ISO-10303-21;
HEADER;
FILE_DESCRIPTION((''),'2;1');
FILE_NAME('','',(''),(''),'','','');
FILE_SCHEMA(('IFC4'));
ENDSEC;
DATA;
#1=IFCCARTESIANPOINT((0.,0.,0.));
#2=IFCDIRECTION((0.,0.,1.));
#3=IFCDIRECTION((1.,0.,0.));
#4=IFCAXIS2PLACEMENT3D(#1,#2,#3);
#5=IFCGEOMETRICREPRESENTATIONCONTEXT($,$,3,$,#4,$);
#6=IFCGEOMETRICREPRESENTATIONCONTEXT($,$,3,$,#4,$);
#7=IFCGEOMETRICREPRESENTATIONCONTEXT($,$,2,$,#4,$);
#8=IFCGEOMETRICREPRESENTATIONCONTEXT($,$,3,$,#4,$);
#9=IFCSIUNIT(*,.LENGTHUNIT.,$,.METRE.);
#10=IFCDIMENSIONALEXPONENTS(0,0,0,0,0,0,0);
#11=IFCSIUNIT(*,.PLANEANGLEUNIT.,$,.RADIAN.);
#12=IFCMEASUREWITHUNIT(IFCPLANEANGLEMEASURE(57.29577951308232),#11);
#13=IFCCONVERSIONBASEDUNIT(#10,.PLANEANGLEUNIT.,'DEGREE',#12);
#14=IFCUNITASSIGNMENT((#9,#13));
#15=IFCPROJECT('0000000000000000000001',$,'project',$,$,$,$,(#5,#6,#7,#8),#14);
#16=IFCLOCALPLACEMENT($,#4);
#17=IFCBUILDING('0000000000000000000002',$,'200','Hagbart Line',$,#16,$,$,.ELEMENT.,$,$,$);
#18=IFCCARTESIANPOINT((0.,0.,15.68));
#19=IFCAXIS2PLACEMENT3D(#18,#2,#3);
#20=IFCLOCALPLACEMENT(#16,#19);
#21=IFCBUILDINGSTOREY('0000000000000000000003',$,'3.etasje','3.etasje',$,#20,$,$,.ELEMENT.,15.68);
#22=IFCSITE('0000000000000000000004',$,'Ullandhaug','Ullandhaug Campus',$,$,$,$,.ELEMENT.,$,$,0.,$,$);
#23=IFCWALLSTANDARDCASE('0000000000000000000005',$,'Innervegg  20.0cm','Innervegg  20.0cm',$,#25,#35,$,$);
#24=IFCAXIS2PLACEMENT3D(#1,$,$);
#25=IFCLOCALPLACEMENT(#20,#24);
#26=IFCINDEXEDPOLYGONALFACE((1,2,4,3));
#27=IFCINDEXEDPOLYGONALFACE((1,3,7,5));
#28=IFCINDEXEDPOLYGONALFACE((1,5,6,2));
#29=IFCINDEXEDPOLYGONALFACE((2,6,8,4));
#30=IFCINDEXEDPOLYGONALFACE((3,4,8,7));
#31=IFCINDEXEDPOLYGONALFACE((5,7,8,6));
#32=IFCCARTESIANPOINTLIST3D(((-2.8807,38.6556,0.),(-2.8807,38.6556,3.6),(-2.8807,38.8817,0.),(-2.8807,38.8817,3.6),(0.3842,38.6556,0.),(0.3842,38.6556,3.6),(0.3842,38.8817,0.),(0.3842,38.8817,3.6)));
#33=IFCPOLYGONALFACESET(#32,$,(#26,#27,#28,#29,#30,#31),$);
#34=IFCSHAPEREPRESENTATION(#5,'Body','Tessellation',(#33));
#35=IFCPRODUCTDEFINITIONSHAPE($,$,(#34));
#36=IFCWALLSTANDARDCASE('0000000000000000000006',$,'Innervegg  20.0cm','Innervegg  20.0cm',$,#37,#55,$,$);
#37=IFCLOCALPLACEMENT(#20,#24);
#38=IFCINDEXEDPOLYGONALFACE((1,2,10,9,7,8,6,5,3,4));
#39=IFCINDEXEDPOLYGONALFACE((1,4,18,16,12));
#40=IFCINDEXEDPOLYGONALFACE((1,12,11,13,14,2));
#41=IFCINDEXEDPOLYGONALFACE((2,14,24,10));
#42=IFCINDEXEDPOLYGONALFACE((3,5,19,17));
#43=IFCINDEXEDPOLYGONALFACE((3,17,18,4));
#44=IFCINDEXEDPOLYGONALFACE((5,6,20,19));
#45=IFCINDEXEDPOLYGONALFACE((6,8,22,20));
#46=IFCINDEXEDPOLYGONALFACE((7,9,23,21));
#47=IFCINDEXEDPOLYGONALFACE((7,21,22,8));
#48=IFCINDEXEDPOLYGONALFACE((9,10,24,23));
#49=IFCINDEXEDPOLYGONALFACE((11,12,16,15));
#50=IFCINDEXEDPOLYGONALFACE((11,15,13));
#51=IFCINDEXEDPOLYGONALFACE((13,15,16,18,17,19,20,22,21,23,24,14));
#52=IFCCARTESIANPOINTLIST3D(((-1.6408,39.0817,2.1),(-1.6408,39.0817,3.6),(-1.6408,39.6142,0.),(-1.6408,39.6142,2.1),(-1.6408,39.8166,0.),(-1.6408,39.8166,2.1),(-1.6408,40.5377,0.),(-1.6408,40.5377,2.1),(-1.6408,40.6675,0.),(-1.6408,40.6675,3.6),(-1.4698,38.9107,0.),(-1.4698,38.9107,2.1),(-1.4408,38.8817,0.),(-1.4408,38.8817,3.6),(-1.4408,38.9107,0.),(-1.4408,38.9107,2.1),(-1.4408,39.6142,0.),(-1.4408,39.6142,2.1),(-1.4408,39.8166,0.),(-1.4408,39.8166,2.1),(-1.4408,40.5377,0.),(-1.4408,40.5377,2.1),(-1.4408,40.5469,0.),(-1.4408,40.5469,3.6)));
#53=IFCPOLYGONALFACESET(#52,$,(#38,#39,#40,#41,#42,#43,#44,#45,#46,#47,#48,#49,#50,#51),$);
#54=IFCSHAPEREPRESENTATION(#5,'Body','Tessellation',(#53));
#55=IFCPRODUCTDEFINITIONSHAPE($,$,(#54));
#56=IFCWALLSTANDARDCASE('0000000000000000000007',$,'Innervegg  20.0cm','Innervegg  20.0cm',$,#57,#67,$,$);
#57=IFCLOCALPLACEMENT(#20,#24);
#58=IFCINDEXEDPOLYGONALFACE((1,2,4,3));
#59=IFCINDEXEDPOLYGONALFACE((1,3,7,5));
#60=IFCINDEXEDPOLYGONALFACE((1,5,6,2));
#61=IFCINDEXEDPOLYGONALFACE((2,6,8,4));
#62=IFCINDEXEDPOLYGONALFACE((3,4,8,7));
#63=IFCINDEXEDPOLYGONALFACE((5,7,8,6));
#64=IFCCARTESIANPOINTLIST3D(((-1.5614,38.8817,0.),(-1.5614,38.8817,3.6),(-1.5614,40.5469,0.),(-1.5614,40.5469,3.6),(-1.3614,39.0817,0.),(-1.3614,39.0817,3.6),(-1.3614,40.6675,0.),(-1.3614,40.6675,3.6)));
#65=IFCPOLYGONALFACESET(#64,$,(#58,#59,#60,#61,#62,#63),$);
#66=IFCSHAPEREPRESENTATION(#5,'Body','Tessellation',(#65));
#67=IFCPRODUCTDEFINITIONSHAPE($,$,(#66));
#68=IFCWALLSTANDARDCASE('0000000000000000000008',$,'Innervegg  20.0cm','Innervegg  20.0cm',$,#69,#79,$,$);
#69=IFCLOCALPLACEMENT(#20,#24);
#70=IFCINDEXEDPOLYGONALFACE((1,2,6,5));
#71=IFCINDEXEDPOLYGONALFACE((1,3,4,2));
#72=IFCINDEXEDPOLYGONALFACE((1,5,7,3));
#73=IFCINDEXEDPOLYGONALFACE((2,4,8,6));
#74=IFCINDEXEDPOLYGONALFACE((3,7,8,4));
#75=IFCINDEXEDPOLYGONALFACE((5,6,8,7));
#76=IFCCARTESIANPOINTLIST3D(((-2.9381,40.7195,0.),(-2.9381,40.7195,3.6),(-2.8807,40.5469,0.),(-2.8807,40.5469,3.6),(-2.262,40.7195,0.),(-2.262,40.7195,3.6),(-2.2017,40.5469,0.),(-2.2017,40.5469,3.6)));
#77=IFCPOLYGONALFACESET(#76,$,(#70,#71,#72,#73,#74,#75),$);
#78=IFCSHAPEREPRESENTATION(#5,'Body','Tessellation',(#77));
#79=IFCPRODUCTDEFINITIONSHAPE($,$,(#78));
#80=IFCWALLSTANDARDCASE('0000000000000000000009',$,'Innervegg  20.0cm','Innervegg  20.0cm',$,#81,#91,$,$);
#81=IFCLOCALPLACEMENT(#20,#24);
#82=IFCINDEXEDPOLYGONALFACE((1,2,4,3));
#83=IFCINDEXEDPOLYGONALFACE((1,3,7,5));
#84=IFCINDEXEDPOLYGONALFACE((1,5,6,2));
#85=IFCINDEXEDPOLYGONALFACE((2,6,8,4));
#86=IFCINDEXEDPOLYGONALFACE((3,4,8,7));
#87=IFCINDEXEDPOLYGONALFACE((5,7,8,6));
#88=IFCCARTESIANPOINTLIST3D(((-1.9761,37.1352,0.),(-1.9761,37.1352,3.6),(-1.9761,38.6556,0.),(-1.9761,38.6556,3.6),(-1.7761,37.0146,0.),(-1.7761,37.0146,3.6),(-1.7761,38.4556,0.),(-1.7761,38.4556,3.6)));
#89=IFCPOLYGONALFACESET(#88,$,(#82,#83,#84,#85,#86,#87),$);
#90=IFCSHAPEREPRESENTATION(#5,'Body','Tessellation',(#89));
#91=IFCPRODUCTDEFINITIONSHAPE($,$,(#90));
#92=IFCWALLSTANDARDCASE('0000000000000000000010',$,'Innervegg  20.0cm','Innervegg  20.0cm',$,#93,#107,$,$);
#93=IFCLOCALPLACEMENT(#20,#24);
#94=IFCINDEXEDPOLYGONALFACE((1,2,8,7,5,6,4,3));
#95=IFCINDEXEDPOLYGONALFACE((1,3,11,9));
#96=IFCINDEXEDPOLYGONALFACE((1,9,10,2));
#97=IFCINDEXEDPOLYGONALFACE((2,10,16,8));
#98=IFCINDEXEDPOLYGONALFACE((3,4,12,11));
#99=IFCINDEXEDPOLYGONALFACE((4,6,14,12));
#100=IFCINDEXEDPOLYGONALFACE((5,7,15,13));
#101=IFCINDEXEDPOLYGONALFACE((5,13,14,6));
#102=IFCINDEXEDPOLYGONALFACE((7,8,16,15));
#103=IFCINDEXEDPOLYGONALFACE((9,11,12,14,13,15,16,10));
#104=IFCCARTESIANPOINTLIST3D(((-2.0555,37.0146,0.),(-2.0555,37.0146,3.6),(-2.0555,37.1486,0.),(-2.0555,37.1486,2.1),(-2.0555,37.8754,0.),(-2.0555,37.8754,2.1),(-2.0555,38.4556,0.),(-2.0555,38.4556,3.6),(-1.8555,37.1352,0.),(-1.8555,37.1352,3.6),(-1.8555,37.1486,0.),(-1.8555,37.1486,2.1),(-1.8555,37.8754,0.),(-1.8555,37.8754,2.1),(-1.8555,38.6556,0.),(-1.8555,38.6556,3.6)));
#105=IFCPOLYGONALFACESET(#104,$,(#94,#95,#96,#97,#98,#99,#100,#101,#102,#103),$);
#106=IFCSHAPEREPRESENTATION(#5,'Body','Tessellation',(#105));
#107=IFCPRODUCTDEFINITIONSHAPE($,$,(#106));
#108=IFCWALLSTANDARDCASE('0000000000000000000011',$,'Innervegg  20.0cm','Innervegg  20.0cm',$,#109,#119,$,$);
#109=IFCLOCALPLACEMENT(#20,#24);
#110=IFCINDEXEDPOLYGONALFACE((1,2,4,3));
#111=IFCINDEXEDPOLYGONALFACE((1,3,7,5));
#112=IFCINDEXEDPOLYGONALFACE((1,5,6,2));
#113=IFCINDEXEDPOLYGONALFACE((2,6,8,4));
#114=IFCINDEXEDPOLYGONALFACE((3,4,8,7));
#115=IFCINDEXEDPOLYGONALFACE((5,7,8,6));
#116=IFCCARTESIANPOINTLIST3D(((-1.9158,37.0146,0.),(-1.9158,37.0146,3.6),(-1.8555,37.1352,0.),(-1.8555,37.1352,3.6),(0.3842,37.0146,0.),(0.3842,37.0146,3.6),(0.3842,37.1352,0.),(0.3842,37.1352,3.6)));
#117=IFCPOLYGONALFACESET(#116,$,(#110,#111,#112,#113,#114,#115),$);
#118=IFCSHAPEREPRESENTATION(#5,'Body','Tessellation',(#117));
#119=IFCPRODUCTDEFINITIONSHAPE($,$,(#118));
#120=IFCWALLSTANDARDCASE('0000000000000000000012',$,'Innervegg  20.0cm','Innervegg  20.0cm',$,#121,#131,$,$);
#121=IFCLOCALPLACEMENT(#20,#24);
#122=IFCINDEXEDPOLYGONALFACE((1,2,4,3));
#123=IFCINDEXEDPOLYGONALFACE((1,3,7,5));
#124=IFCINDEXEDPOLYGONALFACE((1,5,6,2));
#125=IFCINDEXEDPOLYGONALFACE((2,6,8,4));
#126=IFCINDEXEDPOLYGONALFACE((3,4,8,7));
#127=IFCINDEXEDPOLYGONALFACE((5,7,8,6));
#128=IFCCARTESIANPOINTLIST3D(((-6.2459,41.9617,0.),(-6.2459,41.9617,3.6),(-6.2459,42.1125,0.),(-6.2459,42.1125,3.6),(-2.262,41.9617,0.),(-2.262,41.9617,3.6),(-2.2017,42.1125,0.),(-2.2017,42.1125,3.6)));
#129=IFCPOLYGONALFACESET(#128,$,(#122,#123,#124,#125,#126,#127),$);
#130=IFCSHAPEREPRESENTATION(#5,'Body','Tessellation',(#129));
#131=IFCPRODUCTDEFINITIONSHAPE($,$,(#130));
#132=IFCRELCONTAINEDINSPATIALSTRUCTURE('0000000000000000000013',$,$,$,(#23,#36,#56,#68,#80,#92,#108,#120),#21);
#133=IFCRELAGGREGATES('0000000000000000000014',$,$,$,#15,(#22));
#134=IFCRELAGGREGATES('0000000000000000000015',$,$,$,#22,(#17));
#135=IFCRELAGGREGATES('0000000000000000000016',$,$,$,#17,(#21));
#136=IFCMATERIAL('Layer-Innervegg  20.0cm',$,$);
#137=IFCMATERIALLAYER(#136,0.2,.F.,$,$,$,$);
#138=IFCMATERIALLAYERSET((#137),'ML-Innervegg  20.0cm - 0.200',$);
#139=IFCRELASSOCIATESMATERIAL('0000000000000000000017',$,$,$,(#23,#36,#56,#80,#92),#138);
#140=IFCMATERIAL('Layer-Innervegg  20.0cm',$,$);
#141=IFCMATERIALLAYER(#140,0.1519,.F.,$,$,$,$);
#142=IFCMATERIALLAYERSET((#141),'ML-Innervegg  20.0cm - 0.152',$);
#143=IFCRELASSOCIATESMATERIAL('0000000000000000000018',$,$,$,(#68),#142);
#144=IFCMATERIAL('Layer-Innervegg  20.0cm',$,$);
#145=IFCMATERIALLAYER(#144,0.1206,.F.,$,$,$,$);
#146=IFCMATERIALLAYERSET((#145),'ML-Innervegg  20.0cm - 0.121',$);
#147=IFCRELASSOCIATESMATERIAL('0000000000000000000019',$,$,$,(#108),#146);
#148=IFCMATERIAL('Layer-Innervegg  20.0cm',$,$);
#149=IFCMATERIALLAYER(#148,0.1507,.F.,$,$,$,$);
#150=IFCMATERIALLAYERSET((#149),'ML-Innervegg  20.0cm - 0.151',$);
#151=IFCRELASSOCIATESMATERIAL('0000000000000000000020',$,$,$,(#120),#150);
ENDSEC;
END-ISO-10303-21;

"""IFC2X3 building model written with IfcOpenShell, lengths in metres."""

from ifc_helpers import new_model, entity, si_unit, converted_unit, frame, origin_with_axes, place, context, project, spatial, polyline, outline, extrude, material, layer, layer_set, layer_usage, element, save


model = new_model("IFC2X3")

# Units and contexts
context_of_model_1 = context(None, 3, world=origin_with_axes())
context_of_model_2 = context(None, 3, world=origin_with_axes())
context_of_model_3 = context(None, 2, world=origin_with_axes())
context_of_model_4 = context(None, 3, world=origin_with_axes())
ifc_project = project(units=[si_unit("LENGTHUNIT", "METRE"), converted_unit("PLANEANGLEUNIT", "DEGREE", entity("IfcPlaneAngleMeasure", 57.29577951308232), si_unit("PLANEANGLEUNIT", "RADIAN"), dimensions=[0, 0, 0, 0, 0, 0, 0])], contexts=[context_of_model_1, context_of_model_2, context_of_model_3, context_of_model_4])

# Site, building, storey
site = spatial("IfcSite", under=ifc_project, Name="Ullandhaug", Description="Ullandhaug Campus", CompositionType="ELEMENT", RefElevation=0.0)
building_placement = place(None, origin_with_axes())
building = spatial("IfcBuilding", under=site, at=building_placement, Name="200", Description="Hagbart Line", CompositionType="ELEMENT")
storey_placement = place(building_placement, frame((0.0, 0.0, 15.68), z_axis=(0.0, 0.0, 1.0), x_axis=(1.0, 0.0, 0.0)))
storey = spatial("IfcBuildingStorey", under=building, at=storey_placement, Name="3.etasje", Description="3.etasje", CompositionType="ELEMENT", Elevation=15.68)

# Wall
ifc_material_1 = material(Name="Layer-Innervegg  20.0cm")
ifc_layer_1 = layer(ifc_material_1, 0.2, ventilated=False)
ifc_layer_set_1 = layer_set([ifc_layer_1], Name="ML-Innervegg  20.0cm - 0.200")
ifc_layer_usage_1 = layer_usage(ifc_layer_set_1, "AXIS2", "POSITIVE", 0.0)
ifc_material_2 = material(Name="Layer-Innervegg  20.0cm")
ifc_layer_2 = layer(ifc_material_2, 0.1206, ventilated=False)
ifc_layer_set_2 = layer_set([ifc_layer_2], Name="ML-Innervegg  20.0cm - 0.121")
ifc_layer_usage_2 = layer_usage(ifc_layer_set_2, "AXIS2", "POSITIVE", 0.0)
wall_1_placement = place(storey_placement, frame((-2.8807, 38.6556, 0.0), z_axis=(0.0, 0.0, 1.0), x_axis=(1.0, 0.0, 0.0)))
element("IfcWallStandardCase", 1, at=wall_1_placement, inside=storey, material=ifc_layer_usage_1, Name="Innervegg  20.0cm", Description="Innervegg  20.0cm", context=context_of_model_1, shape_type="SweptSolid", body=[
    extrude(outline(polyline([(0.0, 0.0), (3.265, 0.0), (3.265, 0.2261), (0.0, 0.2261), (0.0, 0.0)])), origin_with_axes(), (0.0, 0.0, 1.0), 3.6),
])

# Wall, openings
wall_2_placement = place(storey_placement, frame((-1.6408, 40.6675, 0.0), z_axis=(0.0, 0.0, 1.0), x_axis=(0.0, -1.0, 0.0)))
wall_2 = element("IfcWallStandardCase", 2, at=wall_2_placement, inside=storey, material=ifc_layer_usage_1, Name="Innervegg  20.0cm", Description="Innervegg  20.0cm", context=context_of_model_1, shape_type="SweptSolid", body=[
    extrude(outline(polyline([(0.0, 0.0), (1.5858, 0.0), (1.7858, 0.2), (0.1206, 0.2), (0.0, 0.0)])), frame((0.0, 0.0, 0.0), z_axis=(0.0, 0.0, 1.0), x_axis=(1.0, 0.0, 0.0)), (0.0, 0.0, 1.0), 3.6),
])
opening_1_placement = place(wall_2_placement, frame((1.0533, 0.2, 0.0), z_axis=(0.0, 0.0, 1.0), x_axis=(1.0, 0.0, 0.0)))
element("IfcOpeningElement", 3, at=opening_1_placement, cuts=wall_2, context=context_of_model_1, shape_type="SweptSolid", body=[
    extrude(outline(polyline([(0.0, 0.0), (2.1, 0.0), (2.1, 0.7035), (0.0, 0.7035), (0.0, 0.0)])), frame((0.0, 0.0, 0.0), z_axis=(0.0, 1.0, 0.0), x_axis=(0.0, 0.0, 1.0)), (0.0, 0.0, -1.0), 0.2),
])
opening_2_placement = place(wall_2_placement, frame((0.1298, 0.2, 0.0), z_axis=(0.0, 0.0, 1.0), x_axis=(1.0, 0.0, 0.0)))
element("IfcOpeningElement", 4, at=opening_2_placement, cuts=wall_2, context=context_of_model_1, shape_type="SweptSolid", body=[
    extrude(outline(polyline([(0.0, 0.0), (2.1, 0.0), (2.1, 0.7211), (0.0, 0.7211), (0.0, 0.0)])), frame((0.0, 0.0, 0.0), z_axis=(0.0, 1.0, 0.0), x_axis=(0.0, 0.0, 1.0)), (0.0, 0.0, -1.0), 0.2),
])

# Walls
wall_3_placement = place(storey_placement, frame((-1.3614, 39.0817, 0.0), z_axis=(0.0, 0.0, 1.0), x_axis=(0.0, 1.0, 0.0)))
element("IfcWallStandardCase", 5, at=wall_3_placement, inside=storey, material=ifc_layer_usage_1, Name="Innervegg  20.0cm", Description="Innervegg  20.0cm", context=context_of_model_1, shape_type="SweptSolid", body=[
    extrude(outline(polyline([(0.0, 0.0), (1.5858, 0.0), (1.4652, 0.2), (-0.2, 0.2), (0.0, 0.0)])), frame((0.0, 0.0, 0.0), z_axis=(0.0, 0.0, 1.0), x_axis=(1.0, 0.0, 0.0)), (0.0, 0.0, 1.0), 3.6),
])
ifc_material_3 = material(Name="Layer-Innervegg  20.0cm")
ifc_layer_3 = layer(ifc_material_3, 0.1519, ventilated=False)
ifc_layer_set_3 = layer_set([ifc_layer_3], Name="ML-Innervegg  20.0cm - 0.152")
ifc_layer_usage_3 = layer_usage(ifc_layer_set_3, "AXIS2", "POSITIVE", 0.0)
wall_4_placement = place(storey_placement, frame((-2.262, 40.7195, 0.0), z_axis=(0.0, 0.0, 1.0), x_axis=(-1.0, 0.0, 0.0)))
element("IfcWallStandardCase", 6, at=wall_4_placement, inside=storey, material=ifc_layer_usage_3, Name="Innervegg  20.0cm", Description="Innervegg  20.0cm", context=context_of_model_1, shape_type="SweptSolid", body=[
    extrude(outline(polyline([(0.0, 0.0), (0.6761, 0.0), (0.6188, 0.1726), (-0.0603, 0.1726), (0.0, 0.0)])), frame((0.0, 0.0, 0.0), z_axis=(0.0, 0.0, 1.0), x_axis=(1.0, 0.0, 0.0)), (0.0, 0.0, 1.0), 3.6),
])
wall_5_placement = place(storey_placement, frame((-1.7761, 37.0146, 0.0), z_axis=(0.0, 0.0, 1.0), x_axis=(0.0, 1.0, 0.0)))
element("IfcWallStandardCase", 7, at=wall_5_placement, inside=storey, material=ifc_layer_usage_1, Name="Innervegg  20.0cm", Description="Innervegg  20.0cm", context=context_of_model_1, shape_type="SweptSolid", body=[
    extrude(outline(polyline([(0.0, 0.0), (1.441, 0.0), (1.641, 0.2), (0.1206, 0.2), (0.0, 0.0)])), frame((0.0, 0.0, 0.0), z_axis=(0.0, 0.0, 1.0), x_axis=(1.0, 0.0, 0.0)), (0.0, 0.0, 1.0), 3.6),
])

# Wall, opening
wall_6_placement = place(storey_placement, frame((-2.0555, 38.4556, 0.0), z_axis=(0.0, 0.0, 1.0), x_axis=(0.0, -1.0, 0.0)))
wall_6 = element("IfcWallStandardCase", 8, at=wall_6_placement, inside=storey, material=ifc_layer_usage_1, Name="Innervegg  20.0cm", Description="Innervegg  20.0cm", context=context_of_model_1, shape_type="SweptSolid", body=[
    extrude(outline(polyline([(0.0, 0.0), (1.441, 0.0), (1.3204, 0.2), (-0.2, 0.2), (0.0, 0.0)])), frame((0.0, 0.0, 0.0), z_axis=(0.0, 0.0, 1.0), x_axis=(1.0, 0.0, 0.0)), (0.0, 0.0, 1.0), 3.6),
])
opening_3_placement = place(wall_6_placement, frame((0.5802, 0.2, 0.0), z_axis=(0.0, 0.0, 1.0), x_axis=(1.0, 0.0, 0.0)))
element("IfcOpeningElement", 9, at=opening_3_placement, cuts=wall_6, context=context_of_model_1, shape_type="SweptSolid", body=[
    extrude(outline(polyline([(0.0, 0.0), (2.1, 0.0), (2.1, 0.7269), (0.0, 0.7269), (0.0, 0.0)])), frame((0.0, 0.0, 0.0), z_axis=(0.0, 1.0, 0.0), x_axis=(0.0, 0.0, 1.0)), (0.0, 0.0, -1.0), 0.2),
])

# Walls
wall_7_placement = place(storey_placement, frame((-1.9158, 37.0146, 0.0), z_axis=(0.0, 0.0, 1.0), x_axis=(1.0, 0.0, 0.0)))
element("IfcWallStandardCase", 10, at=wall_7_placement, inside=storey, material=ifc_layer_usage_2, Name="Innervegg  20.0cm", Description="Innervegg  20.0cm", context=context_of_model_1, shape_type="SweptSolid", body=[
    extrude(outline(polyline([(0.0, 0.0), (2.3, 0.0), (2.3, 0.1206), (0.0603, 0.1206), (0.0, 0.0)])), origin_with_axes(), (0.0, 0.0, 1.0), 3.6),
])
ifc_material_4 = material(Name="Layer-Innervegg  20.0cm")
ifc_layer_4 = layer(ifc_material_4, 0.1507, ventilated=False)
ifc_layer_set_4 = layer_set([ifc_layer_4], Name="ML-Innervegg  20.0cm - 0.151")
ifc_layer_usage_4 = layer_usage(ifc_layer_set_4, "AXIS2", "POSITIVE", 0.0)
wall_8_placement = place(storey_placement, frame((-2.2017, 42.1125, 0.0), z_axis=(0.0, 0.0, 1.0), x_axis=(-1.0, 0.0, 0.0)))
element("IfcWallStandardCase", 11, at=wall_8_placement, inside=storey, material=ifc_layer_usage_4, Name="Innervegg  20.0cm", Description="Innervegg  20.0cm", context=context_of_model_1, shape_type="SweptSolid", body=[
    extrude(outline(polyline([(0.0, 0.0), (4.0442, 0.0), (4.0442, 0.1507), (0.0603, 0.1507), (0.0, 0.0)])), frame((0.0, 0.0, 0.0), z_axis=(0.0, 0.0, 1.0), x_axis=(1.0, 0.0, 0.0)), (0.0, 0.0, 1.0), 3.6),
])

save(model, "model.ifc")
